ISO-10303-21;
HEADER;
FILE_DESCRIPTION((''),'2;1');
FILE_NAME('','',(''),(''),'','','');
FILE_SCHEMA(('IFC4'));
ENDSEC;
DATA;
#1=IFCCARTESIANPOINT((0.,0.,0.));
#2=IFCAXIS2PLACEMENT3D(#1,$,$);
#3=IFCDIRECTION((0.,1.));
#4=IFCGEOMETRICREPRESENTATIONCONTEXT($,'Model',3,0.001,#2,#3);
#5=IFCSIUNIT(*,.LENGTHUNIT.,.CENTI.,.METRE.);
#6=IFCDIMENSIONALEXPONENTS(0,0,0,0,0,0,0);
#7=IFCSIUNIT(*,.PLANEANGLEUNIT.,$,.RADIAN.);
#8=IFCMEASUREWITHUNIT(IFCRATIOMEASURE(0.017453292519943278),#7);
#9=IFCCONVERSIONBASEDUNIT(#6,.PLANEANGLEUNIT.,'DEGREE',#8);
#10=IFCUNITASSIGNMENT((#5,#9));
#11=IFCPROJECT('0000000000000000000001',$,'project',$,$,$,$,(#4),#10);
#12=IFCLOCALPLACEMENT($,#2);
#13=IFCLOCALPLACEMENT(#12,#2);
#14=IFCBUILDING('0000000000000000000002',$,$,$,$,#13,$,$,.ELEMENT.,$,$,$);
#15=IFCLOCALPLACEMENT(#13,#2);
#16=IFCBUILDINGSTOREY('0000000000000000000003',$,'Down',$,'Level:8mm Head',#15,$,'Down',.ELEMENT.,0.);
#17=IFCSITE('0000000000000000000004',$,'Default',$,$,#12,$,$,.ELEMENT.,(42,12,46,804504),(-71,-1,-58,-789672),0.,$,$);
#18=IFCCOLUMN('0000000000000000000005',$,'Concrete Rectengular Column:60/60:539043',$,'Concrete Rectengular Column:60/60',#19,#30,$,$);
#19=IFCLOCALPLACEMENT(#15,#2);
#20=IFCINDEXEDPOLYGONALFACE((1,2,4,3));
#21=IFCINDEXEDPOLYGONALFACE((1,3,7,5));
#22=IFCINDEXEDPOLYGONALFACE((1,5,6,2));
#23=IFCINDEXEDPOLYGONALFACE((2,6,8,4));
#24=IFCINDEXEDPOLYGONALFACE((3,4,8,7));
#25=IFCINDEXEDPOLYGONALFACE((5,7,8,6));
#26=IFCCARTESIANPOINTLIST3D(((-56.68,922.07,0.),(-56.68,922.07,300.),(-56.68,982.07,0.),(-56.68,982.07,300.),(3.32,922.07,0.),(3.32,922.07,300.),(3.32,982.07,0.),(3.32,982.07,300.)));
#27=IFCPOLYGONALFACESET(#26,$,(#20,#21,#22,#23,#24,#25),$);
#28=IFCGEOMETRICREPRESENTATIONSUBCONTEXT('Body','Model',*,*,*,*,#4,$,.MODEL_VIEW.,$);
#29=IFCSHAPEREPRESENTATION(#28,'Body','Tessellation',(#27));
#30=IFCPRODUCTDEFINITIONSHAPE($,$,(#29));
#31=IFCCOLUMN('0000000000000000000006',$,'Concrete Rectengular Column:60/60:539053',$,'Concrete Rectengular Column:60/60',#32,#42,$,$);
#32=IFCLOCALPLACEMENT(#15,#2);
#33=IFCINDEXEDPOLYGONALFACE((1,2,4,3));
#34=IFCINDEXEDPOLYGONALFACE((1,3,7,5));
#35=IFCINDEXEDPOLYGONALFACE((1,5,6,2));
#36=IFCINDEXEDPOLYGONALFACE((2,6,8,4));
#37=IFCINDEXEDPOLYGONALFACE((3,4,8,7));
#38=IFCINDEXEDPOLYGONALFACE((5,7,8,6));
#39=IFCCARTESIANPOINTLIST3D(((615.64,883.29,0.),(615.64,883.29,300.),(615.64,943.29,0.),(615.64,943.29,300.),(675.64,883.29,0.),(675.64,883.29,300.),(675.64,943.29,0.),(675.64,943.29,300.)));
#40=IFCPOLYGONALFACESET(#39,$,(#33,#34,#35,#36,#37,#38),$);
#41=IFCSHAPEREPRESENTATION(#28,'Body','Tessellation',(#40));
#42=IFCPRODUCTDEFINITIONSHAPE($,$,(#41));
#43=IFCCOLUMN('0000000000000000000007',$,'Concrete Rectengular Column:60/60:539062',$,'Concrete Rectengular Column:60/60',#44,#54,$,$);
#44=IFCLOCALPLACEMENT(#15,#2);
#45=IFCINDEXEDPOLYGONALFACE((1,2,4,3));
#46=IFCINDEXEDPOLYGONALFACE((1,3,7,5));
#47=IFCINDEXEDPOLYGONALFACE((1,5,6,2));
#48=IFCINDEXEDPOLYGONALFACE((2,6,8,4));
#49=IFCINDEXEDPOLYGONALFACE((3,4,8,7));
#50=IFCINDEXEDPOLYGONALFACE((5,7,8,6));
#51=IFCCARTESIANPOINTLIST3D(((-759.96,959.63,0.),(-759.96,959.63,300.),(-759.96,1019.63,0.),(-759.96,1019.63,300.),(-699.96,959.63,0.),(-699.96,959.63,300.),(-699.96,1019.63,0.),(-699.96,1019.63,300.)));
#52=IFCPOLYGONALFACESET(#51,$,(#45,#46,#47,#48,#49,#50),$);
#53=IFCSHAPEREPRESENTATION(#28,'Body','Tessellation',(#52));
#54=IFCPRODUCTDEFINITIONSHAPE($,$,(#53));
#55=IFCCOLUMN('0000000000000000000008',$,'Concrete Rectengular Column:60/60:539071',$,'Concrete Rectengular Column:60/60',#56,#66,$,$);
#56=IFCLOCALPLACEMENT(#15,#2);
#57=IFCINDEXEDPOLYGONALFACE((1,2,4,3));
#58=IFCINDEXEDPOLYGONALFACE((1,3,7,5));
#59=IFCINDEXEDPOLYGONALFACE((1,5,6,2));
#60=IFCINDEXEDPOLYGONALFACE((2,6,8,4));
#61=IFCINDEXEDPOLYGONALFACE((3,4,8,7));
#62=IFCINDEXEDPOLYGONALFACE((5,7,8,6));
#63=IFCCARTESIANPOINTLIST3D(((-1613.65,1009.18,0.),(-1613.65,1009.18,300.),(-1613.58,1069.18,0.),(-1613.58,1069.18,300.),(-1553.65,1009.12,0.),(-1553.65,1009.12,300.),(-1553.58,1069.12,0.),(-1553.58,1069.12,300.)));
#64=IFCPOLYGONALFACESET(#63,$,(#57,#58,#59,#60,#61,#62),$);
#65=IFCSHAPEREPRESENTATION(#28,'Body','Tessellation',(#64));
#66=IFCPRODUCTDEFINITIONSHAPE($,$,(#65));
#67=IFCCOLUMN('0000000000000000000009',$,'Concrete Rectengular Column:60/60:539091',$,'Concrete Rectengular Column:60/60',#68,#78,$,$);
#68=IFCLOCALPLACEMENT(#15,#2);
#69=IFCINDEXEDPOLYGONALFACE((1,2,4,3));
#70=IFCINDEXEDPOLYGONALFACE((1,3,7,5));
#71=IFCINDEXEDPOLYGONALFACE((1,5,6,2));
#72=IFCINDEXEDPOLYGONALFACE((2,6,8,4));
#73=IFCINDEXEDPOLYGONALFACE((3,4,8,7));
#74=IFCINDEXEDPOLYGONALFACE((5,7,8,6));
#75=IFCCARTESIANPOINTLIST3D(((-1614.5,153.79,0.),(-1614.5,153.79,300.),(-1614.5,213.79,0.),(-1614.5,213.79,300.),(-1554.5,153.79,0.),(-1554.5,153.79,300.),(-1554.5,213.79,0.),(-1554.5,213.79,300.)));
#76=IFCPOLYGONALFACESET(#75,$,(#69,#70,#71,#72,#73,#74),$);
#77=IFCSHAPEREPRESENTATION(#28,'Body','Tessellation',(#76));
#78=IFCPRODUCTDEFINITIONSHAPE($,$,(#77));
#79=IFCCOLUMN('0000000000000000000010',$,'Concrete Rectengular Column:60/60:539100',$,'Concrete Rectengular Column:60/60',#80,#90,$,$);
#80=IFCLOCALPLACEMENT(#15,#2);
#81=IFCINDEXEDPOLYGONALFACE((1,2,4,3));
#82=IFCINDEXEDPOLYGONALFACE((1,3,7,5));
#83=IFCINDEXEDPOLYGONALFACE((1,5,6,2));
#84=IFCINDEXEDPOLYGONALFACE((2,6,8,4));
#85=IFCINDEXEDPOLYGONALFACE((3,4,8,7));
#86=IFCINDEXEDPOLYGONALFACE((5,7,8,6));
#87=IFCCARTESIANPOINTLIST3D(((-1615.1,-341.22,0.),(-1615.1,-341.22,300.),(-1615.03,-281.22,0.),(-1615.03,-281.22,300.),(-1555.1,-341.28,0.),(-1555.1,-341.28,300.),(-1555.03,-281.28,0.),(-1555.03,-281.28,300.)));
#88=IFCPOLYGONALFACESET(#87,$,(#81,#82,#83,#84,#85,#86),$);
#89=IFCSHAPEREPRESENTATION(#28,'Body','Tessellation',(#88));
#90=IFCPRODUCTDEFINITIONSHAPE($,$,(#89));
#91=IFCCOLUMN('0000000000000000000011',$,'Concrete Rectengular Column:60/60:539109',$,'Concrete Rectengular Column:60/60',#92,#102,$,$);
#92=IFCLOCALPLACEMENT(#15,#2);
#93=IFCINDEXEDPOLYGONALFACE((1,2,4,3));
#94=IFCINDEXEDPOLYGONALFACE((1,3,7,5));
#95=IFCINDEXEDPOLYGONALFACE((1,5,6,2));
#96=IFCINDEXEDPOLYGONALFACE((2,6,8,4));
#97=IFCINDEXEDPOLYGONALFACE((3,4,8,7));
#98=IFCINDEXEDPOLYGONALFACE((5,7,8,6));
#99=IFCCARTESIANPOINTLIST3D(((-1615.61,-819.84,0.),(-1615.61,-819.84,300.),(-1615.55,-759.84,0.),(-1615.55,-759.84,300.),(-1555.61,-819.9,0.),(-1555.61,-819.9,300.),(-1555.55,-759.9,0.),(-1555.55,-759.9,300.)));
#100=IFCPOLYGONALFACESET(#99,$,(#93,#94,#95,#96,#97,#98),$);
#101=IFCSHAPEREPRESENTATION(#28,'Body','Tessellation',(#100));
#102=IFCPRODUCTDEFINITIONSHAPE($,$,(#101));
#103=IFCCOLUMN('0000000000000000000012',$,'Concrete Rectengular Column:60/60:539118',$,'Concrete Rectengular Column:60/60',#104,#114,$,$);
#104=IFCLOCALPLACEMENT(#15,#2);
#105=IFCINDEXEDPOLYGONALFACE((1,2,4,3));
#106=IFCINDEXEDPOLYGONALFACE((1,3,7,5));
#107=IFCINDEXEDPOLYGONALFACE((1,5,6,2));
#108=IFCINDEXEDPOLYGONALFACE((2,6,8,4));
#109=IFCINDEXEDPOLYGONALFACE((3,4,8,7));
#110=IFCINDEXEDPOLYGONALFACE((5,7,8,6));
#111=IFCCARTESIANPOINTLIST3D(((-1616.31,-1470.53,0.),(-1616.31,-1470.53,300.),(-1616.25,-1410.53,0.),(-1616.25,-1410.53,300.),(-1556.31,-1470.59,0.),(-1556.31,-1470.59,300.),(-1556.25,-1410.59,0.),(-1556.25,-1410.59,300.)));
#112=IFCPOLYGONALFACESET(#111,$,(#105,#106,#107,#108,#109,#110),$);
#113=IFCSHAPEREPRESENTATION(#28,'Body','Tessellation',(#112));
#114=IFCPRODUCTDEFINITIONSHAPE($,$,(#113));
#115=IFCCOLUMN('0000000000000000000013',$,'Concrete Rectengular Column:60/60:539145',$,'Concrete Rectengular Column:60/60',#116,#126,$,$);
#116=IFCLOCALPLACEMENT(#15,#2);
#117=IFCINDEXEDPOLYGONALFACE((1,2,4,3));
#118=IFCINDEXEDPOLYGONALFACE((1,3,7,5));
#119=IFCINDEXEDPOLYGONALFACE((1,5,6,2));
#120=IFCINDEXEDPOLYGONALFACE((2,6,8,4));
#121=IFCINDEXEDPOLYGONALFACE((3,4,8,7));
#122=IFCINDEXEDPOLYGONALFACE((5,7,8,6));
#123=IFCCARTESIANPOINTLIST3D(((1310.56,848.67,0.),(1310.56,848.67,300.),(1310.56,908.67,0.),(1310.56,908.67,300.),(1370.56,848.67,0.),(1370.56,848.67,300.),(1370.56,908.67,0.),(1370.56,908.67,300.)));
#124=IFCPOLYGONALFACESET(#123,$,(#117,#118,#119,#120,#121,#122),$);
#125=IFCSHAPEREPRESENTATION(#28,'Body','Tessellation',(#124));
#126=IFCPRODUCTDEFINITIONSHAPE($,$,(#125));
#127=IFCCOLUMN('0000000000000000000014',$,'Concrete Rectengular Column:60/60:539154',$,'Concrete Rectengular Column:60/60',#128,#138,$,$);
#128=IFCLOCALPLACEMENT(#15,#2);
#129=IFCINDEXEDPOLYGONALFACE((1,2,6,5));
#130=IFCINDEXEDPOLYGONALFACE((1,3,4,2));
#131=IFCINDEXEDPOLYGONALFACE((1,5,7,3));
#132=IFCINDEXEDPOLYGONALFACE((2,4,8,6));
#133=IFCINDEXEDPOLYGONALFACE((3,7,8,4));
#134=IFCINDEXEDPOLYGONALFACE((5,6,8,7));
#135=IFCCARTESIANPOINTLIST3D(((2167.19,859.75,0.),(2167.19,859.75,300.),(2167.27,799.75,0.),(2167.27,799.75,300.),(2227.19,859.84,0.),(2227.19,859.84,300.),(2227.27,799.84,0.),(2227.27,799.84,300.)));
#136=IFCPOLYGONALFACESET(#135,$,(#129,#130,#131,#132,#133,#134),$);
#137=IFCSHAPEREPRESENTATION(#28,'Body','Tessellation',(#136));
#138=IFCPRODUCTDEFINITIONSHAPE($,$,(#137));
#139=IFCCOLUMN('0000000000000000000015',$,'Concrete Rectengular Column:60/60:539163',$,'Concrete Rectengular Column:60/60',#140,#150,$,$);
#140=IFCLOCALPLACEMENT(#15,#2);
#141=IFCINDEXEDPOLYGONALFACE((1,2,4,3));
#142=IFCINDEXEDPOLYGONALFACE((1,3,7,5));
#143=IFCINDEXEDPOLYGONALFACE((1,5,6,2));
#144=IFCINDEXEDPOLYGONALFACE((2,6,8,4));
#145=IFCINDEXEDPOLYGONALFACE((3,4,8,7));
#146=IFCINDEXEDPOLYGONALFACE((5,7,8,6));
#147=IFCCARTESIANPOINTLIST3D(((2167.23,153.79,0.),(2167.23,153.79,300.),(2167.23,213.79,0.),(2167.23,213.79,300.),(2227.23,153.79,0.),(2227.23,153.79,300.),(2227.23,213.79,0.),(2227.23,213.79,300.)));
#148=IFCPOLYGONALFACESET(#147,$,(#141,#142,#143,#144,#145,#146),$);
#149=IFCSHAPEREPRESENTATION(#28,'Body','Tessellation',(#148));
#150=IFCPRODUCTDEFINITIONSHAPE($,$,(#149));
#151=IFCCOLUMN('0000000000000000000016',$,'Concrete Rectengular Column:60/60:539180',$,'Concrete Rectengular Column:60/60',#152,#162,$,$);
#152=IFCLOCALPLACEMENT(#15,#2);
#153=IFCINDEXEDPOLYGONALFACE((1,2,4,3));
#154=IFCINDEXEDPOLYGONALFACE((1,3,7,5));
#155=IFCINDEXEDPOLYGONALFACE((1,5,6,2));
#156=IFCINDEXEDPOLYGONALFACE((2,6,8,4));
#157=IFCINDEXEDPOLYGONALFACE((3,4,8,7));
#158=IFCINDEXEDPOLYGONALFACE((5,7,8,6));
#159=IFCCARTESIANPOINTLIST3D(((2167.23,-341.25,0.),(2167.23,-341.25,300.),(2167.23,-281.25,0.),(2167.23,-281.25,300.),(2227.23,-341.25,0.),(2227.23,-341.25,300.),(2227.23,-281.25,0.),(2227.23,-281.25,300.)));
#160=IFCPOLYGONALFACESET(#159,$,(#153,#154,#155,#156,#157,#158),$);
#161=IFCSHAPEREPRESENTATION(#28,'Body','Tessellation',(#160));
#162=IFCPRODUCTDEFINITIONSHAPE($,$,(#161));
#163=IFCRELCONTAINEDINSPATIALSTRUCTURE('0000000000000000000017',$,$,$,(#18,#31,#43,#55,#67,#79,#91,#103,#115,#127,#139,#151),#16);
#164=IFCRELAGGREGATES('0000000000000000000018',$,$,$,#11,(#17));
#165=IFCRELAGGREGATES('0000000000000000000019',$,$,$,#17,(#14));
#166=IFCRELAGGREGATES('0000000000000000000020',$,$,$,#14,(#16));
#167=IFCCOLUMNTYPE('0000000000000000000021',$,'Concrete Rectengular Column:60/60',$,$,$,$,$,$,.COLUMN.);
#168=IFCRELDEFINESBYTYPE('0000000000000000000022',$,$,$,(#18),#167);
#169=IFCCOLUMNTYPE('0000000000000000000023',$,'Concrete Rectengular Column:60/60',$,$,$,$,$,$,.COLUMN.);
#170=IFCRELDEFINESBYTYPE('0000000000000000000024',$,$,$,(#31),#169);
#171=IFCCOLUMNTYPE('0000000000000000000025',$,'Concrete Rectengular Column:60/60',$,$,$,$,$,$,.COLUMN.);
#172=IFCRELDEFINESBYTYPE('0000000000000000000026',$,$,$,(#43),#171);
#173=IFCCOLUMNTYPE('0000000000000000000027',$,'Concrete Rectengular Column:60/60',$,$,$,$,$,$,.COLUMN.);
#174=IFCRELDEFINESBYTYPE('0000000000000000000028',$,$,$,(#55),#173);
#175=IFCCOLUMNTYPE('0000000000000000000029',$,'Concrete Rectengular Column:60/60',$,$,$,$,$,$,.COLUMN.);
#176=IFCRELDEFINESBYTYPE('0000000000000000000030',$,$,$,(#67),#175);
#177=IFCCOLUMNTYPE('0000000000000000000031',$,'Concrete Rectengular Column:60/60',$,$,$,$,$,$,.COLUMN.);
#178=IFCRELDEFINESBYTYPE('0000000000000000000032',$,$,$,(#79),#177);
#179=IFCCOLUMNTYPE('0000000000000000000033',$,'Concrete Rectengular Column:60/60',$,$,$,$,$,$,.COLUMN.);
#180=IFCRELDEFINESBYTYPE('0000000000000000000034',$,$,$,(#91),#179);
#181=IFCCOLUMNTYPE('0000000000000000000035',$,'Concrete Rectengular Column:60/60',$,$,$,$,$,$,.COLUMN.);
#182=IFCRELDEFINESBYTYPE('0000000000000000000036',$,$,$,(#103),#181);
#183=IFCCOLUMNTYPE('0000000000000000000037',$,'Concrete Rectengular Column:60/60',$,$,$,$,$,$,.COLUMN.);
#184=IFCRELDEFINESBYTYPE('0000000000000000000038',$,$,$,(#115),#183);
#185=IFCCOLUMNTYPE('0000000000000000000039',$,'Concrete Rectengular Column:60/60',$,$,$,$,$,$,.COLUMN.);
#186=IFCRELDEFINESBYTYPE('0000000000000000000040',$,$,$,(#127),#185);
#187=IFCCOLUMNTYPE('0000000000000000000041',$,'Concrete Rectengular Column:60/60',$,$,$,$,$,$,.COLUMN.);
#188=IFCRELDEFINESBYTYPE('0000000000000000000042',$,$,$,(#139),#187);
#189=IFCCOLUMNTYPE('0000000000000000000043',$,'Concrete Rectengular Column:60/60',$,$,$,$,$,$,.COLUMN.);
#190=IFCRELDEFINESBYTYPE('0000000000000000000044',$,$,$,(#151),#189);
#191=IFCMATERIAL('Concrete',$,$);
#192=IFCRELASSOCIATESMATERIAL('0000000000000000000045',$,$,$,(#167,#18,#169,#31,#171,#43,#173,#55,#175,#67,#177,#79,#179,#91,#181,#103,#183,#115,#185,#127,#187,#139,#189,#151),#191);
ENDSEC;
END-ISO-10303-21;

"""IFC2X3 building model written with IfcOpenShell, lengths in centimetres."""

from ifc_helpers import new_model, entity, si_unit, converted_unit, direction, frame, frame_2d, origin, origin_2d_with_axis, place, context, subcontext, project, spatial, rectangle, extrude, source, transform, mapped, material, type_object, type_shapes, element, save


model = new_model("IFC2X3")

# Units and contexts
model_context = context("Model", 3, precision=0.001, world=origin(), true_north=direction((0.0, 1.0)))
body_context = subcontext(model_context, "Body", "Model", "MODEL_VIEW")
ifc_project = project(units=[si_unit("LENGTHUNIT", "METRE", prefix="CENTI"), converted_unit("PLANEANGLEUNIT", "DEGREE", entity("IfcRatioMeasure", 0.017453292519943278), si_unit("PLANEANGLEUNIT", "RADIAN"), dimensions=[0, 0, 0, 0, 0, 0, 0])], contexts=[model_context])

# Site, building, storey
site_placement = place(None, origin())
site = spatial("IfcSite", under=ifc_project, at=site_placement, Name="Default", CompositionType="ELEMENT", RefLatitude=(42, 12, 46, 804504), RefLongitude=(-71, -1, -58, -789672), RefElevation=0.0)
building_placement = place(site_placement, origin())
building = spatial("IfcBuilding", under=site, at=building_placement, CompositionType="ELEMENT")
storey_placement = place(building_placement, origin())
storey = spatial("IfcBuildingStorey", under=building, at=storey_placement, Name="Down", ObjectType="Level:8mm Head", LongName="Down", CompositionType="ELEMENT", Elevation=0.0)

# Columns
ifc_material = material(Name="Concrete")
column_type_1 = type_object("IfcColumnType", Name="Concrete Rectengular Column:60/60", PredefinedType="COLUMN", material=ifc_material)
shared_shape_1 = source(origin(), body_context, "Body", "SweptSolid", [
    extrude(rectangle(XDim=60.0, YDim=60.0, at=frame_2d((0.0, 0.0), x_axis=(1.0, 0.0))), frame((-26.68, 952.07, 0.0), z_axis=(0.0, 0.0, 1.0), x_axis=(0.0, -1.0, 0.0)), (0.0, 0.0, 1.0), 300.0),
])
type_shapes(column_type_1, [shared_shape_1])
column_1_placement = place(storey_placement, origin())
element("IfcColumn", 1, at=column_1_placement, inside=storey, type_object=column_type_1, material=ifc_material, Name="Concrete Rectengular Column:60/60:539043", ObjectType="Concrete Rectengular Column:60/60", context=body_context, shape_type="MappedRepresentation", body=[
    mapped(shared_shape_1, transform((0.0, 0.0, 0.0), scale=1.0)),
])
column_type_2 = type_object("IfcColumnType", Name="Concrete Rectengular Column:60/60", PredefinedType="COLUMN", material=ifc_material)
shared_shape_2 = source(origin(), body_context, "Body", "SweptSolid", [
    extrude(rectangle(XDim=60.0, YDim=60.0, at=origin_2d_with_axis()), frame((645.64, 913.29, 0.0), z_axis=(0.0, 0.0, 1.0), x_axis=(0.0, -1.0, 0.0)), (0.0, 0.0, 1.0), 300.0),
])
type_shapes(column_type_2, [shared_shape_2])
column_2_placement = place(storey_placement, origin())
element("IfcColumn", 2, at=column_2_placement, inside=storey, type_object=column_type_2, material=ifc_material, Name="Concrete Rectengular Column:60/60:539053", ObjectType="Concrete Rectengular Column:60/60", context=body_context, shape_type="MappedRepresentation", body=[
    mapped(shared_shape_2, transform((0.0, 0.0, 0.0), scale=1.0)),
])
column_type_3 = type_object("IfcColumnType", Name="Concrete Rectengular Column:60/60", PredefinedType="COLUMN", material=ifc_material)
shared_shape_3 = source(origin(), body_context, "Body", "SweptSolid", [
    extrude(rectangle(XDim=60.0, YDim=60.0, at=frame_2d((0.0, 0.0), x_axis=(1.0, 0.0))), frame((-729.96, 989.63, 0.0), z_axis=(0.0, 0.0, 1.0), x_axis=(0.0, -1.0, 0.0)), (0.0, 0.0, 1.0), 300.0),
])
type_shapes(column_type_3, [shared_shape_3])
column_3_placement = place(storey_placement, origin())
element("IfcColumn", 3, at=column_3_placement, inside=storey, type_object=column_type_3, material=ifc_material, Name="Concrete Rectengular Column:60/60:539062", ObjectType="Concrete Rectengular Column:60/60", context=body_context, shape_type="MappedRepresentation", body=[
    mapped(shared_shape_3, transform((0.0, 0.0, 0.0), scale=1.0)),
])
column_type_4 = type_object("IfcColumnType", Name="Concrete Rectengular Column:60/60", PredefinedType="COLUMN", material=ifc_material)
shared_shape_4 = source(origin(), body_context, "Body", "SweptSolid", [
    extrude(rectangle(XDim=60.0, YDim=60.0, at=frame_2d((0.0, 0.0), x_axis=(1.0, 0.0))), frame((-1583.61, 1039.15, 0.0), z_axis=(0.0, 0.0, 1.0), x_axis=(0.001075, 0.999999, 0.0)), (0.0, 0.0, 1.0), 300.0),
])
type_shapes(column_type_4, [shared_shape_4])
column_4_placement = place(storey_placement, origin())
element("IfcColumn", 4, at=column_4_placement, inside=storey, type_object=column_type_4, material=ifc_material, Name="Concrete Rectengular Column:60/60:539071", ObjectType="Concrete Rectengular Column:60/60", context=body_context, shape_type="MappedRepresentation", body=[
    mapped(shared_shape_4, transform((0.0, 0.0, 0.0), scale=1.0)),
])
column_type_5 = type_object("IfcColumnType", Name="Concrete Rectengular Column:60/60", PredefinedType="COLUMN", material=ifc_material)
shared_shape_5 = source(origin(), body_context, "Body", "SweptSolid", [
    extrude(rectangle(XDim=60.0, YDim=60.0, at=frame_2d((0.0, 0.0), x_axis=(1.0, 0.0))), frame((-1584.5, 183.79, 0.0), z_axis=(0.0, 0.0, 1.0), x_axis=(0.0, -1.0, 0.0)), (0.0, 0.0, 1.0), 300.0),
])
type_shapes(column_type_5, [shared_shape_5])
column_5_placement = place(storey_placement, origin())
element("IfcColumn", 5, at=column_5_placement, inside=storey, type_object=column_type_5, material=ifc_material, Name="Concrete Rectengular Column:60/60:539091", ObjectType="Concrete Rectengular Column:60/60", context=body_context, shape_type="MappedRepresentation", body=[
    mapped(shared_shape_5, transform((0.0, 0.0, 0.0), scale=1.0)),
])
column_type_6 = type_object("IfcColumnType", Name="Concrete Rectengular Column:60/60", PredefinedType="COLUMN", material=ifc_material)
shared_shape_6 = source(origin(), body_context, "Body", "SweptSolid", [
    extrude(rectangle(XDim=60.0, YDim=60.0, at=frame_2d((0.0, 0.0), x_axis=(1.0, 0.0))), frame((-1585.07, -311.25, 0.0), z_axis=(0.0, 0.0, 1.0), x_axis=(0.001075, 0.999999, 0.0)), (0.0, 0.0, 1.0), 300.0),
])
type_shapes(column_type_6, [shared_shape_6])
column_6_placement = place(storey_placement, origin())
element("IfcColumn", 6, at=column_6_placement, inside=storey, type_object=column_type_6, material=ifc_material, Name="Concrete Rectengular Column:60/60:539100", ObjectType="Concrete Rectengular Column:60/60", context=body_context, shape_type="MappedRepresentation", body=[
    mapped(shared_shape_6, transform((0.0, 0.0, 0.0), scale=1.0)),
])
column_type_7 = type_object("IfcColumnType", Name="Concrete Rectengular Column:60/60", PredefinedType="COLUMN", material=ifc_material)
shared_shape_7 = source(origin(), body_context, "Body", "SweptSolid", [
    extrude(rectangle(XDim=60.0, YDim=60.0, at=origin_2d_with_axis()), frame((-1585.58, -789.87, 0.0), z_axis=(0.0, 0.0, 1.0), x_axis=(0.001075, 0.999999, 0.0)), (0.0, 0.0, 1.0), 300.0),
])
type_shapes(column_type_7, [shared_shape_7])
column_7_placement = place(storey_placement, origin())
element("IfcColumn", 7, at=column_7_placement, inside=storey, type_object=column_type_7, material=ifc_material, Name="Concrete Rectengular Column:60/60:539109", ObjectType="Concrete Rectengular Column:60/60", context=body_context, shape_type="MappedRepresentation", body=[
    mapped(shared_shape_7, transform((0.0, 0.0, 0.0), scale=1.0)),
])
column_type_8 = type_object("IfcColumnType", Name="Concrete Rectengular Column:60/60", PredefinedType="COLUMN", material=ifc_material)
shared_shape_8 = source(origin(), body_context, "Body", "SweptSolid", [
    extrude(rectangle(XDim=60.0, YDim=60.0, at=frame_2d((0.0, 0.0), x_axis=(1.0, 0.0))), frame((-1586.28, -1440.56, 0.0), z_axis=(0.0, 0.0, 1.0), x_axis=(0.001075, 0.999999, 0.0)), (0.0, 0.0, 1.0), 300.0),
])
type_shapes(column_type_8, [shared_shape_8])
column_8_placement = place(storey_placement, origin())
element("IfcColumn", 8, at=column_8_placement, inside=storey, type_object=column_type_8, material=ifc_material, Name="Concrete Rectengular Column:60/60:539118", ObjectType="Concrete Rectengular Column:60/60", context=body_context, shape_type="MappedRepresentation", body=[
    mapped(shared_shape_8, transform((0.0, 0.0, 0.0), scale=1.0)),
])
column_type_9 = type_object("IfcColumnType", Name="Concrete Rectengular Column:60/60", PredefinedType="COLUMN", material=ifc_material)
shared_shape_9 = source(origin(), body_context, "Body", "SweptSolid", [
    extrude(rectangle(XDim=60.0, YDim=60.0, at=frame_2d((0.0, 0.0), x_axis=(1.0, 0.0))), frame((1340.56, 878.67, 0.0), z_axis=(0.0, 0.0, 1.0), x_axis=(0.0, -1.0, 0.0)), (0.0, 0.0, 1.0), 300.0),
])
type_shapes(column_type_9, [shared_shape_9])
column_9_placement = place(storey_placement, origin())
element("IfcColumn", 9, at=column_9_placement, inside=storey, type_object=column_type_9, material=ifc_material, Name="Concrete Rectengular Column:60/60:539145", ObjectType="Concrete Rectengular Column:60/60", context=body_context, shape_type="MappedRepresentation", body=[
    mapped(shared_shape_9, transform((0.0, 0.0, 0.0), scale=1.0)),
])
column_type_10 = type_object("IfcColumnType", Name="Concrete Rectengular Column:60/60", PredefinedType="COLUMN", material=ifc_material)
shared_shape_10 = source(origin(), body_context, "Body", "SweptSolid", [
    extrude(rectangle(XDim=60.0, YDim=60.0, at=origin_2d_with_axis()), frame((2197.23, 829.8, 0.0), z_axis=(0.0, 0.0, 1.0), x_axis=(-0.001395, 0.999999, 0.0)), (0.0, 0.0, 1.0), 300.0),
])
type_shapes(column_type_10, [shared_shape_10])
column_10_placement = place(storey_placement, origin())
element("IfcColumn", 10, at=column_10_placement, inside=storey, type_object=column_type_10, material=ifc_material, Name="Concrete Rectengular Column:60/60:539154", ObjectType="Concrete Rectengular Column:60/60", context=body_context, shape_type="MappedRepresentation", body=[
    mapped(shared_shape_10, transform((0.0, 0.0, 0.0), scale=1.0)),
])
column_type_11 = type_object("IfcColumnType", Name="Concrete Rectengular Column:60/60", PredefinedType="COLUMN", material=ifc_material)
shared_shape_11 = source(origin(), body_context, "Body", "SweptSolid", [
    extrude(rectangle(XDim=60.0, YDim=60.0, at=origin_2d_with_axis()), frame((2197.23, 183.79, 0.0), z_axis=(0.0, 0.0, 1.0), x_axis=(0.0, -1.0, 0.0)), (0.0, 0.0, 1.0), 300.0),
])
type_shapes(column_type_11, [shared_shape_11])
column_11_placement = place(storey_placement, origin())
element("IfcColumn", 11, at=column_11_placement, inside=storey, type_object=column_type_11, material=ifc_material, Name="Concrete Rectengular Column:60/60:539163", ObjectType="Concrete Rectengular Column:60/60", context=body_context, shape_type="MappedRepresentation", body=[
    mapped(shared_shape_11, transform((0.0, 0.0, 0.0), scale=1.0)),
])
column_type_12 = type_object("IfcColumnType", Name="Concrete Rectengular Column:60/60", PredefinedType="COLUMN", material=ifc_material)
shared_shape_12 = source(origin(), body_context, "Body", "SweptSolid", [
    extrude(rectangle(XDim=60.0, YDim=60.0, at=origin_2d_with_axis()), frame((2197.23, -311.25, 0.0), z_axis=(0.0, 0.0, 1.0), x_axis=(0.0, -1.0, 0.0)), (0.0, 0.0, 1.0), 300.0),
])
type_shapes(column_type_12, [shared_shape_12])
column_12_placement = place(storey_placement, origin())
element("IfcColumn", 12, at=column_12_placement, inside=storey, type_object=column_type_12, material=ifc_material, Name="Concrete Rectengular Column:60/60:539180", ObjectType="Concrete Rectengular Column:60/60", context=body_context, shape_type="MappedRepresentation", body=[
    mapped(shared_shape_12, transform((0.0, 0.0, 0.0), scale=1.0)),
])

save(model, "model.ifc")
